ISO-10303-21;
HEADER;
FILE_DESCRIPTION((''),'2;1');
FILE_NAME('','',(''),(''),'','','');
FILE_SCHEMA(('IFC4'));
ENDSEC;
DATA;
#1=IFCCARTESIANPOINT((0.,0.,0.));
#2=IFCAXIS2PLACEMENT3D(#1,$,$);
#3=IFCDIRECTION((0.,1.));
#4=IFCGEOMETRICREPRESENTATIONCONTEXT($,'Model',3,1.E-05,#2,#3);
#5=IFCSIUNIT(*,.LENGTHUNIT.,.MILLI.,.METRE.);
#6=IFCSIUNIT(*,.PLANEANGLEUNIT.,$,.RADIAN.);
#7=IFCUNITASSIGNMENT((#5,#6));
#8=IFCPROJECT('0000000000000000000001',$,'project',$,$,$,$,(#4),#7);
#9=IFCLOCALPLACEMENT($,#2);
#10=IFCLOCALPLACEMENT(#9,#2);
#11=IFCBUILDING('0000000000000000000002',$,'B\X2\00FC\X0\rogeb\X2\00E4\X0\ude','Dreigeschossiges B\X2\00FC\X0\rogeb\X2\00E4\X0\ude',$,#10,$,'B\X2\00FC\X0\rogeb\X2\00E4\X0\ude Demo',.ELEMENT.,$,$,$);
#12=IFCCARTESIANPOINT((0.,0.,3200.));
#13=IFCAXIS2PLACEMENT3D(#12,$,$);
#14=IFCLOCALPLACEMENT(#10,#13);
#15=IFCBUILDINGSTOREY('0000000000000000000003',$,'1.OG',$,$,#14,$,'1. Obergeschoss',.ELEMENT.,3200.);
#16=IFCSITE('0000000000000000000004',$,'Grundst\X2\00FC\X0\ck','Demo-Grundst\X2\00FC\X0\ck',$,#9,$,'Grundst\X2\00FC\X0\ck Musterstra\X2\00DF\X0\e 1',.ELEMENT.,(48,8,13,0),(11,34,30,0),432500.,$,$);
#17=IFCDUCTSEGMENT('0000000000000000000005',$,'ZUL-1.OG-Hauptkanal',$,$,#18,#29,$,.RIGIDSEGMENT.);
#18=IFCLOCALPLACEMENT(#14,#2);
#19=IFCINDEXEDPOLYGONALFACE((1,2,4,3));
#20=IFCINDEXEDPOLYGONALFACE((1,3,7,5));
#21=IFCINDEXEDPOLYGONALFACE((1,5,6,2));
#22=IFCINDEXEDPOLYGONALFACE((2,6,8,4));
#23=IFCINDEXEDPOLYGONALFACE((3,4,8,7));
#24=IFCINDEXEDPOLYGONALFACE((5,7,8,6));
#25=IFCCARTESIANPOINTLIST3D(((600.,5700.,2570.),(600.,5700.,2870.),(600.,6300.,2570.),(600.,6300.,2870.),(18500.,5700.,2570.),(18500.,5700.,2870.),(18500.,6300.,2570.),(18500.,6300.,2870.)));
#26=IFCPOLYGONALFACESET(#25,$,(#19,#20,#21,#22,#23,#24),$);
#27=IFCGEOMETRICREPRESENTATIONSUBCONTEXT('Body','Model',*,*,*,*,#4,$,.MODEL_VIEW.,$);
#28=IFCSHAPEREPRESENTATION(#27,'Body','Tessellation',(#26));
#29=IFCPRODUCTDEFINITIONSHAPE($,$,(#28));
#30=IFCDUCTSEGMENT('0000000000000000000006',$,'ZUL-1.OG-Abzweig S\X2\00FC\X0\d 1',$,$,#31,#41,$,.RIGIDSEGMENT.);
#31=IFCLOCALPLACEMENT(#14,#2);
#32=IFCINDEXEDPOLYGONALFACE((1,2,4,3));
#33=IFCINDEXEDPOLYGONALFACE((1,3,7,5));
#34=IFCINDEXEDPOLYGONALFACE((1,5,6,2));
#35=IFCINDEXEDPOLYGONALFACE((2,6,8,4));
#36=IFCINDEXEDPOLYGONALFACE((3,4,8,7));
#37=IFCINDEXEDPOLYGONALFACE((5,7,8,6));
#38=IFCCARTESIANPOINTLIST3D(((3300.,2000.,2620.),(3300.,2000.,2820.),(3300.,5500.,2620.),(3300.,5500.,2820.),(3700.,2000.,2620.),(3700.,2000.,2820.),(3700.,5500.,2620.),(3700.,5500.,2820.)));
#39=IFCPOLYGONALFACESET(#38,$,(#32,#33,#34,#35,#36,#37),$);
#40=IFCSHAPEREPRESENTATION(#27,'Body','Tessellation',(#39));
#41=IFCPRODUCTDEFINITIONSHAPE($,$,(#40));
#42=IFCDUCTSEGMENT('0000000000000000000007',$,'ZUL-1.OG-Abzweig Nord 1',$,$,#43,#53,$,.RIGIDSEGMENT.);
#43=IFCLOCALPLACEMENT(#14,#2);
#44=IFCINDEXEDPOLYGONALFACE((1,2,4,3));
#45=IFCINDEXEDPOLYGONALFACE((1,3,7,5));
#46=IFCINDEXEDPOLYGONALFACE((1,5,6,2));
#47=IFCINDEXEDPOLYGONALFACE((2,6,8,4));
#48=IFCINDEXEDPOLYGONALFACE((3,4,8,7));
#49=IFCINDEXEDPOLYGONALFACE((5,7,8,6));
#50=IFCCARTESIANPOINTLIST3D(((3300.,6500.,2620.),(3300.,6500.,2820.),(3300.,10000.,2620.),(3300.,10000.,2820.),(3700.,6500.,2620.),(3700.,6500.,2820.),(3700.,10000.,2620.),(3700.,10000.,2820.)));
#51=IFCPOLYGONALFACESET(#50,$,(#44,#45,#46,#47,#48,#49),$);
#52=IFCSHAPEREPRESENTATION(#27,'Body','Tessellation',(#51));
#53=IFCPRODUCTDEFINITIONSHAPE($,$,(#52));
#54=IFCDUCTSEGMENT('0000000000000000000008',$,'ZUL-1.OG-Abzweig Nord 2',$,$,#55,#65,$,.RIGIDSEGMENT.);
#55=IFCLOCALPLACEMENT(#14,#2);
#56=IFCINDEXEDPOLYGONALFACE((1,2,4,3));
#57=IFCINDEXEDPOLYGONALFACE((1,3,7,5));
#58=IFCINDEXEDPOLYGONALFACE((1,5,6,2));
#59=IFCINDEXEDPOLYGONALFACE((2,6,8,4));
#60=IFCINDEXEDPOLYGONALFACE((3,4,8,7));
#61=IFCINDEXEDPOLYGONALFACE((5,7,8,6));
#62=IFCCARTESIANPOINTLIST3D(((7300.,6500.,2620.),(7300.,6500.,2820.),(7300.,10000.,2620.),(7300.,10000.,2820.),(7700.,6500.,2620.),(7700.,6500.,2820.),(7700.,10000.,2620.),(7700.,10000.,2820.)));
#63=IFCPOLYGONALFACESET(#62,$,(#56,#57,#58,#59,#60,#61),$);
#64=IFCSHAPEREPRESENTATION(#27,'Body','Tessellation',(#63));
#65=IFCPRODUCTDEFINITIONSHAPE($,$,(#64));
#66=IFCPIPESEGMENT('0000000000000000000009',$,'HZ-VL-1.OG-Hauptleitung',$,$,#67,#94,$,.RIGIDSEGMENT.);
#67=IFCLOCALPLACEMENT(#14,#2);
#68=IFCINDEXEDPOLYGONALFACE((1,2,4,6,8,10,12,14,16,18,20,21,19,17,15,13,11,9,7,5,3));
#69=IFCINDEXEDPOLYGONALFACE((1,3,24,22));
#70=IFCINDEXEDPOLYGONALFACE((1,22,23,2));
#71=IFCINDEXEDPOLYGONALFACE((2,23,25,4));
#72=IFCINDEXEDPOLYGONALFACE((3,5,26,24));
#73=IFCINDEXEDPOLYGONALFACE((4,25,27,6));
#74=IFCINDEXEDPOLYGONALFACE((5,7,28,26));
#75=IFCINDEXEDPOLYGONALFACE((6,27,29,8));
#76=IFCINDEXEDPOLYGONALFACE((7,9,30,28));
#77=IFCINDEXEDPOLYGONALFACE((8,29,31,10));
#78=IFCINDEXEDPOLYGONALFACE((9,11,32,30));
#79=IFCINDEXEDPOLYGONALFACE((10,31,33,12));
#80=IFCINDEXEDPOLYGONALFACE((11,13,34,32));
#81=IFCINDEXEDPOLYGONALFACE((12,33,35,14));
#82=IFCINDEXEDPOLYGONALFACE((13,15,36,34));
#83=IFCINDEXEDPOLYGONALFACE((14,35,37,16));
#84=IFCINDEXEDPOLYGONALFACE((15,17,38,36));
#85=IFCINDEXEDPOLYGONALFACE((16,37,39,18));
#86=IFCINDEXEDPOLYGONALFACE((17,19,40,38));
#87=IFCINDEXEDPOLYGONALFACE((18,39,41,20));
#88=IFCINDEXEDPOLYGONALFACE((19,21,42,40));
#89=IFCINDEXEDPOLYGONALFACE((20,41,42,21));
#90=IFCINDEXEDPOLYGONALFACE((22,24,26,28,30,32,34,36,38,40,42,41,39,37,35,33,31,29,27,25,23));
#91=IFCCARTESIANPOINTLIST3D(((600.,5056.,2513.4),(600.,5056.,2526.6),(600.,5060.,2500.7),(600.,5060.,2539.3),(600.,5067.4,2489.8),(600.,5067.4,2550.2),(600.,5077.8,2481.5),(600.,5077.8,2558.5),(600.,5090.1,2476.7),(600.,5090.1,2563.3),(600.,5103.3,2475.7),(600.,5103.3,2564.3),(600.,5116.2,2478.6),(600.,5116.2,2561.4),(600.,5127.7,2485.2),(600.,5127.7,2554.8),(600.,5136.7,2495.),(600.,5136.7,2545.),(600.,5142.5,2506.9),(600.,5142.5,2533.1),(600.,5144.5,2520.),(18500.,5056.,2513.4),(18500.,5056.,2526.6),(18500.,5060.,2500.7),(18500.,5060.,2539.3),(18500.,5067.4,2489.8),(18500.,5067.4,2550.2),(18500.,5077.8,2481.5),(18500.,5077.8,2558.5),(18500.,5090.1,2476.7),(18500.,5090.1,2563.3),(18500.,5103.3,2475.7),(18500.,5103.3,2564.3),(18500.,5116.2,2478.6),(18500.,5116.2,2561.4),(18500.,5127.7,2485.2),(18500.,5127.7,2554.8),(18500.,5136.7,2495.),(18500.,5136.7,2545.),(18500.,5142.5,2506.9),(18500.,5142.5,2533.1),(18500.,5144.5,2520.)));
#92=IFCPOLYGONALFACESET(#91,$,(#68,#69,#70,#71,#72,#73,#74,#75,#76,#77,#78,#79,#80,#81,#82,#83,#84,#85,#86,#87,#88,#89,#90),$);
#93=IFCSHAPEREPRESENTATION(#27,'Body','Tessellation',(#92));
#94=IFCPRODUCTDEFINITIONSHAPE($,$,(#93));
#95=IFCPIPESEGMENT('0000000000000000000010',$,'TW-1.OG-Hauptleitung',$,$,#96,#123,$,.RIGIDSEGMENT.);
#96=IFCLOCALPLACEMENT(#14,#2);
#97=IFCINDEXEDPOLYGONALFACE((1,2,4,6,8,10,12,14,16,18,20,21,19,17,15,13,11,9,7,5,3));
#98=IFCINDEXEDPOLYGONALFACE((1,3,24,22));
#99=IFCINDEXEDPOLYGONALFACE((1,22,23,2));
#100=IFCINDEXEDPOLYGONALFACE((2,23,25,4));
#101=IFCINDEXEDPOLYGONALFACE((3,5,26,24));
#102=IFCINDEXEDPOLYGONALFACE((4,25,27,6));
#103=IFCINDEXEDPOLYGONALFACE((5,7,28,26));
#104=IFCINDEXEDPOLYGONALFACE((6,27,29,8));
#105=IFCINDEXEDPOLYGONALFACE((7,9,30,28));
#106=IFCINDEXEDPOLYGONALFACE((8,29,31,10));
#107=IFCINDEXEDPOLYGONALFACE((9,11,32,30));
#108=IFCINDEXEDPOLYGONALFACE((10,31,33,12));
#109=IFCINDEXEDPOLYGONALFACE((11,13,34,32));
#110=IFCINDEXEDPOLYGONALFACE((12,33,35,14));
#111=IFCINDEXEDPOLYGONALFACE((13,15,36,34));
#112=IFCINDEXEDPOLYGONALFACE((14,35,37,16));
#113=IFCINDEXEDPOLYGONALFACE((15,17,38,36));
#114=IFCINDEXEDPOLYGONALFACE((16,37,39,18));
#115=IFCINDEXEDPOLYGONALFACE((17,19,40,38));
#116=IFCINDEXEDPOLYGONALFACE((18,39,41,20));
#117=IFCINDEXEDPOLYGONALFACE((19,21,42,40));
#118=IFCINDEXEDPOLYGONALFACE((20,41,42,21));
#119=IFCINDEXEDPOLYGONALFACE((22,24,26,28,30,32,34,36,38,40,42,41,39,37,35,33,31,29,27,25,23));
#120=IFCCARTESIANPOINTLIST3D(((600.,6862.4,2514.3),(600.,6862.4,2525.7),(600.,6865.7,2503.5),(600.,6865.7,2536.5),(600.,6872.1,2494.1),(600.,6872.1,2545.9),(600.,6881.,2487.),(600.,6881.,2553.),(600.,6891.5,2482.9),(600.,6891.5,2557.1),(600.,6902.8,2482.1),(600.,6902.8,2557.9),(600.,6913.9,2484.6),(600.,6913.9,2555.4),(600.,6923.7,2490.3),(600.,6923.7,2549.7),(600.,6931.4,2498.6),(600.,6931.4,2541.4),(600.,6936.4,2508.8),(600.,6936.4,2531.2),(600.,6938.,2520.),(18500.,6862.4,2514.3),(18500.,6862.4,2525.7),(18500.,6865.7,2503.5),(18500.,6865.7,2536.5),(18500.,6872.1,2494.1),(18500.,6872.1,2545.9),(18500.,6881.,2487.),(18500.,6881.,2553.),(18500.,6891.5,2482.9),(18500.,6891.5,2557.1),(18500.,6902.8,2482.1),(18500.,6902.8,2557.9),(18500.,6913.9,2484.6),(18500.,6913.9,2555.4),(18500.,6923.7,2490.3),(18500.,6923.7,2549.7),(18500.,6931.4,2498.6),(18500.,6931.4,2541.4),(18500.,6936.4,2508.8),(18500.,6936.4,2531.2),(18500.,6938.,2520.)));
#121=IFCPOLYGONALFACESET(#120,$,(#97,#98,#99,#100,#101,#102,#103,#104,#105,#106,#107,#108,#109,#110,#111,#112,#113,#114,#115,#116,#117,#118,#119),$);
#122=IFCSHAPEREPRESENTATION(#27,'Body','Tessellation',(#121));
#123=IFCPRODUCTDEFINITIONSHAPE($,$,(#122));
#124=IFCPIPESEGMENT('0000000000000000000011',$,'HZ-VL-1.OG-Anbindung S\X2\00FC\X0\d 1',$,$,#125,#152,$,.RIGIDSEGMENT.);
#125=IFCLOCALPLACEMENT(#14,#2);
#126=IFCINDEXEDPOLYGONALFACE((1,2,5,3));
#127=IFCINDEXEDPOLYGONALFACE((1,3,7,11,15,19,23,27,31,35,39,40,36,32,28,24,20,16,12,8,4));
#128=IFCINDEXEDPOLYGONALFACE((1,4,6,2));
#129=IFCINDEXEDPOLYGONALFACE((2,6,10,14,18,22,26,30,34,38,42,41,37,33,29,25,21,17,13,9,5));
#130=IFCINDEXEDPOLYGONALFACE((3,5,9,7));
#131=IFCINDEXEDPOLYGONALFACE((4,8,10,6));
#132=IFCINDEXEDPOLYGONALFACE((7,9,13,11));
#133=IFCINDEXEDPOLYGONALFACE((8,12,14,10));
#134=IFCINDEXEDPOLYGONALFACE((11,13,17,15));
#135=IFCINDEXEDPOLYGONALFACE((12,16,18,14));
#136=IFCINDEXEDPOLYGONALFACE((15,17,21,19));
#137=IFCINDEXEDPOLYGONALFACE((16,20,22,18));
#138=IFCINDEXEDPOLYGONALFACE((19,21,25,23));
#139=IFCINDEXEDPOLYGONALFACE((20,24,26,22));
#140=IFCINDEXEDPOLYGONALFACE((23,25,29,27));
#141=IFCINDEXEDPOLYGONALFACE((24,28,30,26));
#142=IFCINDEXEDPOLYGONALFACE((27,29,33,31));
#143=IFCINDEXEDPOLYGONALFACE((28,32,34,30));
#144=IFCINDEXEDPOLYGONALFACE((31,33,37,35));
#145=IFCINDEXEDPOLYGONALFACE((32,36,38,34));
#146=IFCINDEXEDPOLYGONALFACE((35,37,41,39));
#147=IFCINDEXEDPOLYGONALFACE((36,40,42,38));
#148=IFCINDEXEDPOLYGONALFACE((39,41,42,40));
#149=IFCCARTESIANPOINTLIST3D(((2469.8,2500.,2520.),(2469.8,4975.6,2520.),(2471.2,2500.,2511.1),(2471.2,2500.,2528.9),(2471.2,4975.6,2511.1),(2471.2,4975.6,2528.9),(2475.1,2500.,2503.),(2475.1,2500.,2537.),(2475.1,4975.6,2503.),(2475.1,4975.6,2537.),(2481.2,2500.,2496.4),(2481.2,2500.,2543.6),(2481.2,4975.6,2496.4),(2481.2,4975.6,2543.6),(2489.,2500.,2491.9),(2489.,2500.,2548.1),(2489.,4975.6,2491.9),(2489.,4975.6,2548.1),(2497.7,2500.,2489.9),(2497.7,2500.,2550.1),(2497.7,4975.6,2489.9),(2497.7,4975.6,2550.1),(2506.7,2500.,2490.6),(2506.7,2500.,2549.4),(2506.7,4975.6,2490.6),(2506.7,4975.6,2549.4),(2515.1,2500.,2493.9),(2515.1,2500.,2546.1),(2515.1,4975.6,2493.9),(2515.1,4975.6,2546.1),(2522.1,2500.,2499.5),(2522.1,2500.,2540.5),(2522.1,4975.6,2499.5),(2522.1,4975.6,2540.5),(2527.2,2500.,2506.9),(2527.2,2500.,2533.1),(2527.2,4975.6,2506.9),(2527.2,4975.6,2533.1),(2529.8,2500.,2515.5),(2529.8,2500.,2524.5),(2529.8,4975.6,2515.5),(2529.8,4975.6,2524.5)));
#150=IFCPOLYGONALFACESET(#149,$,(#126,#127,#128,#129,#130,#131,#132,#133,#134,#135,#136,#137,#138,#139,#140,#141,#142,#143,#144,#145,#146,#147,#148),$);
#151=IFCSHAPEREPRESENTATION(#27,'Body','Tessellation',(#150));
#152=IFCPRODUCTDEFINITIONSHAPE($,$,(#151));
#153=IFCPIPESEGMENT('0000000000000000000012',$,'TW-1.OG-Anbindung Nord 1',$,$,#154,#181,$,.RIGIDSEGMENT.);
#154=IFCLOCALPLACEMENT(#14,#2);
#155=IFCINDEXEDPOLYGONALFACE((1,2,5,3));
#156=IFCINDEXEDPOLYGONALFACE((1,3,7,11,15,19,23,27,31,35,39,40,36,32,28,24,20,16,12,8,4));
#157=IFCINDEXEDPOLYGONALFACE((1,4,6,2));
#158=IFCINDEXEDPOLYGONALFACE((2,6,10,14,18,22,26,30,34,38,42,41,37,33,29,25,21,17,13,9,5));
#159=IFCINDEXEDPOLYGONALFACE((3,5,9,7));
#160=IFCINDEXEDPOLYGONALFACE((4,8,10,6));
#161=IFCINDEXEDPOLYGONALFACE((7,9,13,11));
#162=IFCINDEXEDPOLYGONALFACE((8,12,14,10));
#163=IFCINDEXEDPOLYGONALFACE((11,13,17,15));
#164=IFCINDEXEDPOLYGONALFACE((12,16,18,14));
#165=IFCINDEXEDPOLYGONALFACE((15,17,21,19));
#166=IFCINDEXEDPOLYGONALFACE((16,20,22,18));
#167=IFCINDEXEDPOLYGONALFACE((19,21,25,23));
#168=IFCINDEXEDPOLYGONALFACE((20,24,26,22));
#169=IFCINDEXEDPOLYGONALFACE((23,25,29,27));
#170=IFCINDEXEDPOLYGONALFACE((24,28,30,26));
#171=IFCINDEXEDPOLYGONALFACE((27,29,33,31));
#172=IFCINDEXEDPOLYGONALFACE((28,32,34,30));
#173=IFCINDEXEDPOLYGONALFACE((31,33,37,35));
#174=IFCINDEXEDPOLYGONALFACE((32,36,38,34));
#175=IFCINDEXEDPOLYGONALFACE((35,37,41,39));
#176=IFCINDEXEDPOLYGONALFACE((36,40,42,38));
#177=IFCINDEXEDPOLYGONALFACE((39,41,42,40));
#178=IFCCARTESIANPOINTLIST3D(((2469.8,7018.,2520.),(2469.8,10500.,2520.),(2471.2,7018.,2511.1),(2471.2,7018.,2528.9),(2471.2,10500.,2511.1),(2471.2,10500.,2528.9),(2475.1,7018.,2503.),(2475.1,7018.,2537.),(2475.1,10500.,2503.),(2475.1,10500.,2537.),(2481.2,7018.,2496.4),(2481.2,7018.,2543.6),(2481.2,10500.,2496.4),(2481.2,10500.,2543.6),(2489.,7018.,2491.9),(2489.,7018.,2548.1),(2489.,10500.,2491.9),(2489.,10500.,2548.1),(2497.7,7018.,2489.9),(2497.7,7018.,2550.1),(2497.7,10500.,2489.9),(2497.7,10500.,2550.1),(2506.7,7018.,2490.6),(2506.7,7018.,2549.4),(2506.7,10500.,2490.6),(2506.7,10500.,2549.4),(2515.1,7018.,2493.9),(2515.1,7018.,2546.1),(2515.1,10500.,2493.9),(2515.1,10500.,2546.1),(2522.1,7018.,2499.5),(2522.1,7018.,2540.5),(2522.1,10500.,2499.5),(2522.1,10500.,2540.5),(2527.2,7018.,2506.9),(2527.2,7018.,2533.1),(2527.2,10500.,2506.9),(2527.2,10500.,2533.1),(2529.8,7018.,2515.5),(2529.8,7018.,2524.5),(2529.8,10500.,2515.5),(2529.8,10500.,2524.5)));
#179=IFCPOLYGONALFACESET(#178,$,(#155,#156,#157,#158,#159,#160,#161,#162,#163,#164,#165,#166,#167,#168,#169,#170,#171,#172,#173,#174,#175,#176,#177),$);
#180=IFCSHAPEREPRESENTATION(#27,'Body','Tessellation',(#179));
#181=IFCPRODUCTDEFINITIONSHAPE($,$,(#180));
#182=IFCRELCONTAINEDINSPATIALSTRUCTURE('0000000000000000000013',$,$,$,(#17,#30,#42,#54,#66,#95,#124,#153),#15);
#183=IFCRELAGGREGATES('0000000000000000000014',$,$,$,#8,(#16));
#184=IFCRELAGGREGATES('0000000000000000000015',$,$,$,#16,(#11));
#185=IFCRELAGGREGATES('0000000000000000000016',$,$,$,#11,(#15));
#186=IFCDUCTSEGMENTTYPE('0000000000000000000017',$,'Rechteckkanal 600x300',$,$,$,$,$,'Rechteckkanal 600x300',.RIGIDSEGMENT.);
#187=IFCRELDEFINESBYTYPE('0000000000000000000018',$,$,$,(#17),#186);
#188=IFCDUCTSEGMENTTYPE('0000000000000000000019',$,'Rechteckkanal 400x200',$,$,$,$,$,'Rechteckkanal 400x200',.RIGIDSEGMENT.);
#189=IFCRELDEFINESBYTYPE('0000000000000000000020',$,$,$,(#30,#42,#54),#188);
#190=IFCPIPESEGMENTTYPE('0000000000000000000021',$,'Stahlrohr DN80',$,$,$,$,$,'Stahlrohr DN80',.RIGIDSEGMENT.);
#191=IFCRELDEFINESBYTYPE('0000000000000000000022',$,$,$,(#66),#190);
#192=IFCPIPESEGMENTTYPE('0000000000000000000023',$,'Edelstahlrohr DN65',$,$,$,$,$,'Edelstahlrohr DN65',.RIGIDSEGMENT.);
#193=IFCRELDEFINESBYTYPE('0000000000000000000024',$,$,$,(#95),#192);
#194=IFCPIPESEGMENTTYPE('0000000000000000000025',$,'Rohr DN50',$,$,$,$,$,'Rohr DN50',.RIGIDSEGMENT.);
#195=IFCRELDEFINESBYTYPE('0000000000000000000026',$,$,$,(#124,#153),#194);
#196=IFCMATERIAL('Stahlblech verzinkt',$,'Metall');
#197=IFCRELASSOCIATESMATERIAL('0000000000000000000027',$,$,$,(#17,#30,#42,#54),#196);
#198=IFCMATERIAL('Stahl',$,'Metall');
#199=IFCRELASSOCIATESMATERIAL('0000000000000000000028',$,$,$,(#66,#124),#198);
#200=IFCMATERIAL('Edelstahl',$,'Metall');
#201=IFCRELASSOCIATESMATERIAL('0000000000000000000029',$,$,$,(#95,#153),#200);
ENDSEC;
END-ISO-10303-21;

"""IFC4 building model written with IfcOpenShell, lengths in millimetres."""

from ifc_helpers import new_model, si_unit, direction, frame, origin, origin_2d, place, context, subcontext, project, spatial, rectangle, circle, extrude, material, type_object, element, save


model = new_model("IFC4")

# Units and contexts
model_context = context("Model", 3, precision=1e-05, world=origin(), true_north=direction((0.0, 1.0)))
body_context = subcontext(model_context, "Body", "Model", "MODEL_VIEW")
ifc_project = project(units=[si_unit("LENGTHUNIT", "METRE", prefix="MILLI"), si_unit("PLANEANGLEUNIT", "RADIAN")], contexts=[model_context])

# Site, building, storey
site_placement = place(None, origin())
site = spatial("IfcSite", under=ifc_project, at=site_placement, Name="Grundstück", Description="Demo-Grundstück", LongName="Grundstück Musterstraße 1", CompositionType="ELEMENT", RefLatitude=(48, 8, 13, 0), RefLongitude=(11, 34, 30, 0), RefElevation=432500.0)
building_placement = place(site_placement, origin())
building = spatial("IfcBuilding", under=site, at=building_placement, Name="Bürogebäude", Description="Dreigeschossiges Bürogebäude", LongName="Bürogebäude Demo", CompositionType="ELEMENT")
storey_placement = place(building_placement, frame((0.0, 0.0, 3200.0)))
storey = spatial("IfcBuildingStorey", under=building, at=storey_placement, Name="1.OG", LongName="1. Obergeschoss", CompositionType="ELEMENT", Elevation=3200.0)

# Duct segments
ifc_material_1 = material(Name="Stahlblech verzinkt", Category="Metall")
duct_segment_type_1 = type_object("IfcDuctSegmentType", Name="Rechteckkanal 600x300", ElementType="Rechteckkanal 600x300", PredefinedType="RIGIDSEGMENT")
duct_segment_placement = place(storey_placement, frame((600.0, 6000.0, 2720.0)))
element("IfcDuctSegment", 1, at=duct_segment_placement, inside=storey, type_object=duct_segment_type_1, material=ifc_material_1, Name="ZUL-1.OG-Hauptkanal", PredefinedType="RIGIDSEGMENT", context=body_context, shape_type="SweptSolid", body=[
    extrude(rectangle(XDim=600.0, YDim=300.0, at=origin_2d()), frame((0.0, 0.0, 0.0), z_axis=(1.0, 0.0, 0.0), x_axis=(0.0, 1.0, 0.0)), (0.0, 0.0, 1.0), 17900.0),
])
duct_segment_type_2 = type_object("IfcDuctSegmentType", Name="Rechteckkanal 400x200", ElementType="Rechteckkanal 400x200", PredefinedType="RIGIDSEGMENT")
for number, where, name in (
    (2, (3500.0, 2000.0, 2720.0), "ZUL-1.OG-Abzweig Süd 1"),
    (3, (3500.0, 6500.0, 2720.0), "ZUL-1.OG-Abzweig Nord 1"),
    (4, (7500.0, 6500.0, 2720.0), "ZUL-1.OG-Abzweig Nord 2"),
):
    element("IfcDuctSegment", number, at=place(storey_placement, frame(where)), inside=storey, type_object=duct_segment_type_2, material=ifc_material_1, Name=name, PredefinedType="RIGIDSEGMENT", context=body_context, shape_type="SweptSolid", body=[
        extrude(rectangle(XDim=400.0, YDim=200.0, at=origin_2d()), frame((0.0, 0.0, 0.0), z_axis=(0.0, 1.0, 0.0), x_axis=(-1.0, 0.0, 0.0)), (0.0, 0.0, 1.0), 3500.0),
    ])

# Pipe segments
ifc_material_2 = material(Name="Stahl", Category="Metall")
pipe_segment_type_1 = type_object("IfcPipeSegmentType", Name="Stahlrohr DN80", ElementType="Stahlrohr DN80", PredefinedType="RIGIDSEGMENT")
pipe_segment_1_placement = place(storey_placement, frame((600.0, 5100.0, 2520.0)))
element("IfcPipeSegment", 5, at=pipe_segment_1_placement, inside=storey, type_object=pipe_segment_type_1, material=ifc_material_2, Name="HZ-VL-1.OG-Hauptleitung", PredefinedType="RIGIDSEGMENT", context=body_context, shape_type="SweptSolid", body=[
    extrude(circle(Radius=44.5, at=origin_2d()), frame((0.0, 0.0, 0.0), z_axis=(1.0, 0.0, 0.0), x_axis=(0.0, 1.0, 0.0)), (0.0, 0.0, 1.0), 17900.0),
])
ifc_material_3 = material(Name="Edelstahl", Category="Metall")
pipe_segment_type_2 = type_object("IfcPipeSegmentType", Name="Edelstahlrohr DN65", ElementType="Edelstahlrohr DN65", PredefinedType="RIGIDSEGMENT")
pipe_segment_2_placement = place(storey_placement, frame((600.0, 6900.0, 2520.0)))
element("IfcPipeSegment", 6, at=pipe_segment_2_placement, inside=storey, type_object=pipe_segment_type_2, material=ifc_material_3, Name="TW-1.OG-Hauptleitung", PredefinedType="RIGIDSEGMENT", context=body_context, shape_type="SweptSolid", body=[
    extrude(circle(Radius=38.0, at=origin_2d()), frame((0.0, 0.0, 0.0), z_axis=(1.0, 0.0, 0.0), x_axis=(0.0, 1.0, 0.0)), (0.0, 0.0, 1.0), 17900.0),
])
pipe_segment_type_3 = type_object("IfcPipeSegmentType", Name="Rohr DN50", ElementType="Rohr DN50", PredefinedType="RIGIDSEGMENT")
pipe_segment_3_placement = place(storey_placement, frame((2500.0, 2500.0, 2520.0)))
element("IfcPipeSegment", 7, at=pipe_segment_3_placement, inside=storey, type_object=pipe_segment_type_3, material=ifc_material_2, Name="HZ-VL-1.OG-Anbindung Süd 1", PredefinedType="RIGIDSEGMENT", context=body_context, shape_type="SweptSolid", body=[
    extrude(circle(Radius=30.1, at=origin_2d()), frame((0.0, 0.0, 0.0), z_axis=(0.0, 1.0, 0.0), x_axis=(-1.0, 0.0, 0.0)), (0.0, 0.0, 1.0), 2475.6),
])
pipe_segment_4_placement = place(storey_placement, frame((2500.0, 7018.1, 2520.0)))
element("IfcPipeSegment", 8, at=pipe_segment_4_placement, inside=storey, type_object=pipe_segment_type_3, material=ifc_material_3, Name="TW-1.OG-Anbindung Nord 1", PredefinedType="RIGIDSEGMENT", context=body_context, shape_type="SweptSolid", body=[
    extrude(circle(Radius=30.1, at=origin_2d()), frame((0.0, 0.0, 0.0), z_axis=(0.0, 1.0, 0.0), x_axis=(-1.0, 0.0, 0.0)), (0.0, 0.0, 1.0), 3481.9),
])

save(model, "model.ifc")
